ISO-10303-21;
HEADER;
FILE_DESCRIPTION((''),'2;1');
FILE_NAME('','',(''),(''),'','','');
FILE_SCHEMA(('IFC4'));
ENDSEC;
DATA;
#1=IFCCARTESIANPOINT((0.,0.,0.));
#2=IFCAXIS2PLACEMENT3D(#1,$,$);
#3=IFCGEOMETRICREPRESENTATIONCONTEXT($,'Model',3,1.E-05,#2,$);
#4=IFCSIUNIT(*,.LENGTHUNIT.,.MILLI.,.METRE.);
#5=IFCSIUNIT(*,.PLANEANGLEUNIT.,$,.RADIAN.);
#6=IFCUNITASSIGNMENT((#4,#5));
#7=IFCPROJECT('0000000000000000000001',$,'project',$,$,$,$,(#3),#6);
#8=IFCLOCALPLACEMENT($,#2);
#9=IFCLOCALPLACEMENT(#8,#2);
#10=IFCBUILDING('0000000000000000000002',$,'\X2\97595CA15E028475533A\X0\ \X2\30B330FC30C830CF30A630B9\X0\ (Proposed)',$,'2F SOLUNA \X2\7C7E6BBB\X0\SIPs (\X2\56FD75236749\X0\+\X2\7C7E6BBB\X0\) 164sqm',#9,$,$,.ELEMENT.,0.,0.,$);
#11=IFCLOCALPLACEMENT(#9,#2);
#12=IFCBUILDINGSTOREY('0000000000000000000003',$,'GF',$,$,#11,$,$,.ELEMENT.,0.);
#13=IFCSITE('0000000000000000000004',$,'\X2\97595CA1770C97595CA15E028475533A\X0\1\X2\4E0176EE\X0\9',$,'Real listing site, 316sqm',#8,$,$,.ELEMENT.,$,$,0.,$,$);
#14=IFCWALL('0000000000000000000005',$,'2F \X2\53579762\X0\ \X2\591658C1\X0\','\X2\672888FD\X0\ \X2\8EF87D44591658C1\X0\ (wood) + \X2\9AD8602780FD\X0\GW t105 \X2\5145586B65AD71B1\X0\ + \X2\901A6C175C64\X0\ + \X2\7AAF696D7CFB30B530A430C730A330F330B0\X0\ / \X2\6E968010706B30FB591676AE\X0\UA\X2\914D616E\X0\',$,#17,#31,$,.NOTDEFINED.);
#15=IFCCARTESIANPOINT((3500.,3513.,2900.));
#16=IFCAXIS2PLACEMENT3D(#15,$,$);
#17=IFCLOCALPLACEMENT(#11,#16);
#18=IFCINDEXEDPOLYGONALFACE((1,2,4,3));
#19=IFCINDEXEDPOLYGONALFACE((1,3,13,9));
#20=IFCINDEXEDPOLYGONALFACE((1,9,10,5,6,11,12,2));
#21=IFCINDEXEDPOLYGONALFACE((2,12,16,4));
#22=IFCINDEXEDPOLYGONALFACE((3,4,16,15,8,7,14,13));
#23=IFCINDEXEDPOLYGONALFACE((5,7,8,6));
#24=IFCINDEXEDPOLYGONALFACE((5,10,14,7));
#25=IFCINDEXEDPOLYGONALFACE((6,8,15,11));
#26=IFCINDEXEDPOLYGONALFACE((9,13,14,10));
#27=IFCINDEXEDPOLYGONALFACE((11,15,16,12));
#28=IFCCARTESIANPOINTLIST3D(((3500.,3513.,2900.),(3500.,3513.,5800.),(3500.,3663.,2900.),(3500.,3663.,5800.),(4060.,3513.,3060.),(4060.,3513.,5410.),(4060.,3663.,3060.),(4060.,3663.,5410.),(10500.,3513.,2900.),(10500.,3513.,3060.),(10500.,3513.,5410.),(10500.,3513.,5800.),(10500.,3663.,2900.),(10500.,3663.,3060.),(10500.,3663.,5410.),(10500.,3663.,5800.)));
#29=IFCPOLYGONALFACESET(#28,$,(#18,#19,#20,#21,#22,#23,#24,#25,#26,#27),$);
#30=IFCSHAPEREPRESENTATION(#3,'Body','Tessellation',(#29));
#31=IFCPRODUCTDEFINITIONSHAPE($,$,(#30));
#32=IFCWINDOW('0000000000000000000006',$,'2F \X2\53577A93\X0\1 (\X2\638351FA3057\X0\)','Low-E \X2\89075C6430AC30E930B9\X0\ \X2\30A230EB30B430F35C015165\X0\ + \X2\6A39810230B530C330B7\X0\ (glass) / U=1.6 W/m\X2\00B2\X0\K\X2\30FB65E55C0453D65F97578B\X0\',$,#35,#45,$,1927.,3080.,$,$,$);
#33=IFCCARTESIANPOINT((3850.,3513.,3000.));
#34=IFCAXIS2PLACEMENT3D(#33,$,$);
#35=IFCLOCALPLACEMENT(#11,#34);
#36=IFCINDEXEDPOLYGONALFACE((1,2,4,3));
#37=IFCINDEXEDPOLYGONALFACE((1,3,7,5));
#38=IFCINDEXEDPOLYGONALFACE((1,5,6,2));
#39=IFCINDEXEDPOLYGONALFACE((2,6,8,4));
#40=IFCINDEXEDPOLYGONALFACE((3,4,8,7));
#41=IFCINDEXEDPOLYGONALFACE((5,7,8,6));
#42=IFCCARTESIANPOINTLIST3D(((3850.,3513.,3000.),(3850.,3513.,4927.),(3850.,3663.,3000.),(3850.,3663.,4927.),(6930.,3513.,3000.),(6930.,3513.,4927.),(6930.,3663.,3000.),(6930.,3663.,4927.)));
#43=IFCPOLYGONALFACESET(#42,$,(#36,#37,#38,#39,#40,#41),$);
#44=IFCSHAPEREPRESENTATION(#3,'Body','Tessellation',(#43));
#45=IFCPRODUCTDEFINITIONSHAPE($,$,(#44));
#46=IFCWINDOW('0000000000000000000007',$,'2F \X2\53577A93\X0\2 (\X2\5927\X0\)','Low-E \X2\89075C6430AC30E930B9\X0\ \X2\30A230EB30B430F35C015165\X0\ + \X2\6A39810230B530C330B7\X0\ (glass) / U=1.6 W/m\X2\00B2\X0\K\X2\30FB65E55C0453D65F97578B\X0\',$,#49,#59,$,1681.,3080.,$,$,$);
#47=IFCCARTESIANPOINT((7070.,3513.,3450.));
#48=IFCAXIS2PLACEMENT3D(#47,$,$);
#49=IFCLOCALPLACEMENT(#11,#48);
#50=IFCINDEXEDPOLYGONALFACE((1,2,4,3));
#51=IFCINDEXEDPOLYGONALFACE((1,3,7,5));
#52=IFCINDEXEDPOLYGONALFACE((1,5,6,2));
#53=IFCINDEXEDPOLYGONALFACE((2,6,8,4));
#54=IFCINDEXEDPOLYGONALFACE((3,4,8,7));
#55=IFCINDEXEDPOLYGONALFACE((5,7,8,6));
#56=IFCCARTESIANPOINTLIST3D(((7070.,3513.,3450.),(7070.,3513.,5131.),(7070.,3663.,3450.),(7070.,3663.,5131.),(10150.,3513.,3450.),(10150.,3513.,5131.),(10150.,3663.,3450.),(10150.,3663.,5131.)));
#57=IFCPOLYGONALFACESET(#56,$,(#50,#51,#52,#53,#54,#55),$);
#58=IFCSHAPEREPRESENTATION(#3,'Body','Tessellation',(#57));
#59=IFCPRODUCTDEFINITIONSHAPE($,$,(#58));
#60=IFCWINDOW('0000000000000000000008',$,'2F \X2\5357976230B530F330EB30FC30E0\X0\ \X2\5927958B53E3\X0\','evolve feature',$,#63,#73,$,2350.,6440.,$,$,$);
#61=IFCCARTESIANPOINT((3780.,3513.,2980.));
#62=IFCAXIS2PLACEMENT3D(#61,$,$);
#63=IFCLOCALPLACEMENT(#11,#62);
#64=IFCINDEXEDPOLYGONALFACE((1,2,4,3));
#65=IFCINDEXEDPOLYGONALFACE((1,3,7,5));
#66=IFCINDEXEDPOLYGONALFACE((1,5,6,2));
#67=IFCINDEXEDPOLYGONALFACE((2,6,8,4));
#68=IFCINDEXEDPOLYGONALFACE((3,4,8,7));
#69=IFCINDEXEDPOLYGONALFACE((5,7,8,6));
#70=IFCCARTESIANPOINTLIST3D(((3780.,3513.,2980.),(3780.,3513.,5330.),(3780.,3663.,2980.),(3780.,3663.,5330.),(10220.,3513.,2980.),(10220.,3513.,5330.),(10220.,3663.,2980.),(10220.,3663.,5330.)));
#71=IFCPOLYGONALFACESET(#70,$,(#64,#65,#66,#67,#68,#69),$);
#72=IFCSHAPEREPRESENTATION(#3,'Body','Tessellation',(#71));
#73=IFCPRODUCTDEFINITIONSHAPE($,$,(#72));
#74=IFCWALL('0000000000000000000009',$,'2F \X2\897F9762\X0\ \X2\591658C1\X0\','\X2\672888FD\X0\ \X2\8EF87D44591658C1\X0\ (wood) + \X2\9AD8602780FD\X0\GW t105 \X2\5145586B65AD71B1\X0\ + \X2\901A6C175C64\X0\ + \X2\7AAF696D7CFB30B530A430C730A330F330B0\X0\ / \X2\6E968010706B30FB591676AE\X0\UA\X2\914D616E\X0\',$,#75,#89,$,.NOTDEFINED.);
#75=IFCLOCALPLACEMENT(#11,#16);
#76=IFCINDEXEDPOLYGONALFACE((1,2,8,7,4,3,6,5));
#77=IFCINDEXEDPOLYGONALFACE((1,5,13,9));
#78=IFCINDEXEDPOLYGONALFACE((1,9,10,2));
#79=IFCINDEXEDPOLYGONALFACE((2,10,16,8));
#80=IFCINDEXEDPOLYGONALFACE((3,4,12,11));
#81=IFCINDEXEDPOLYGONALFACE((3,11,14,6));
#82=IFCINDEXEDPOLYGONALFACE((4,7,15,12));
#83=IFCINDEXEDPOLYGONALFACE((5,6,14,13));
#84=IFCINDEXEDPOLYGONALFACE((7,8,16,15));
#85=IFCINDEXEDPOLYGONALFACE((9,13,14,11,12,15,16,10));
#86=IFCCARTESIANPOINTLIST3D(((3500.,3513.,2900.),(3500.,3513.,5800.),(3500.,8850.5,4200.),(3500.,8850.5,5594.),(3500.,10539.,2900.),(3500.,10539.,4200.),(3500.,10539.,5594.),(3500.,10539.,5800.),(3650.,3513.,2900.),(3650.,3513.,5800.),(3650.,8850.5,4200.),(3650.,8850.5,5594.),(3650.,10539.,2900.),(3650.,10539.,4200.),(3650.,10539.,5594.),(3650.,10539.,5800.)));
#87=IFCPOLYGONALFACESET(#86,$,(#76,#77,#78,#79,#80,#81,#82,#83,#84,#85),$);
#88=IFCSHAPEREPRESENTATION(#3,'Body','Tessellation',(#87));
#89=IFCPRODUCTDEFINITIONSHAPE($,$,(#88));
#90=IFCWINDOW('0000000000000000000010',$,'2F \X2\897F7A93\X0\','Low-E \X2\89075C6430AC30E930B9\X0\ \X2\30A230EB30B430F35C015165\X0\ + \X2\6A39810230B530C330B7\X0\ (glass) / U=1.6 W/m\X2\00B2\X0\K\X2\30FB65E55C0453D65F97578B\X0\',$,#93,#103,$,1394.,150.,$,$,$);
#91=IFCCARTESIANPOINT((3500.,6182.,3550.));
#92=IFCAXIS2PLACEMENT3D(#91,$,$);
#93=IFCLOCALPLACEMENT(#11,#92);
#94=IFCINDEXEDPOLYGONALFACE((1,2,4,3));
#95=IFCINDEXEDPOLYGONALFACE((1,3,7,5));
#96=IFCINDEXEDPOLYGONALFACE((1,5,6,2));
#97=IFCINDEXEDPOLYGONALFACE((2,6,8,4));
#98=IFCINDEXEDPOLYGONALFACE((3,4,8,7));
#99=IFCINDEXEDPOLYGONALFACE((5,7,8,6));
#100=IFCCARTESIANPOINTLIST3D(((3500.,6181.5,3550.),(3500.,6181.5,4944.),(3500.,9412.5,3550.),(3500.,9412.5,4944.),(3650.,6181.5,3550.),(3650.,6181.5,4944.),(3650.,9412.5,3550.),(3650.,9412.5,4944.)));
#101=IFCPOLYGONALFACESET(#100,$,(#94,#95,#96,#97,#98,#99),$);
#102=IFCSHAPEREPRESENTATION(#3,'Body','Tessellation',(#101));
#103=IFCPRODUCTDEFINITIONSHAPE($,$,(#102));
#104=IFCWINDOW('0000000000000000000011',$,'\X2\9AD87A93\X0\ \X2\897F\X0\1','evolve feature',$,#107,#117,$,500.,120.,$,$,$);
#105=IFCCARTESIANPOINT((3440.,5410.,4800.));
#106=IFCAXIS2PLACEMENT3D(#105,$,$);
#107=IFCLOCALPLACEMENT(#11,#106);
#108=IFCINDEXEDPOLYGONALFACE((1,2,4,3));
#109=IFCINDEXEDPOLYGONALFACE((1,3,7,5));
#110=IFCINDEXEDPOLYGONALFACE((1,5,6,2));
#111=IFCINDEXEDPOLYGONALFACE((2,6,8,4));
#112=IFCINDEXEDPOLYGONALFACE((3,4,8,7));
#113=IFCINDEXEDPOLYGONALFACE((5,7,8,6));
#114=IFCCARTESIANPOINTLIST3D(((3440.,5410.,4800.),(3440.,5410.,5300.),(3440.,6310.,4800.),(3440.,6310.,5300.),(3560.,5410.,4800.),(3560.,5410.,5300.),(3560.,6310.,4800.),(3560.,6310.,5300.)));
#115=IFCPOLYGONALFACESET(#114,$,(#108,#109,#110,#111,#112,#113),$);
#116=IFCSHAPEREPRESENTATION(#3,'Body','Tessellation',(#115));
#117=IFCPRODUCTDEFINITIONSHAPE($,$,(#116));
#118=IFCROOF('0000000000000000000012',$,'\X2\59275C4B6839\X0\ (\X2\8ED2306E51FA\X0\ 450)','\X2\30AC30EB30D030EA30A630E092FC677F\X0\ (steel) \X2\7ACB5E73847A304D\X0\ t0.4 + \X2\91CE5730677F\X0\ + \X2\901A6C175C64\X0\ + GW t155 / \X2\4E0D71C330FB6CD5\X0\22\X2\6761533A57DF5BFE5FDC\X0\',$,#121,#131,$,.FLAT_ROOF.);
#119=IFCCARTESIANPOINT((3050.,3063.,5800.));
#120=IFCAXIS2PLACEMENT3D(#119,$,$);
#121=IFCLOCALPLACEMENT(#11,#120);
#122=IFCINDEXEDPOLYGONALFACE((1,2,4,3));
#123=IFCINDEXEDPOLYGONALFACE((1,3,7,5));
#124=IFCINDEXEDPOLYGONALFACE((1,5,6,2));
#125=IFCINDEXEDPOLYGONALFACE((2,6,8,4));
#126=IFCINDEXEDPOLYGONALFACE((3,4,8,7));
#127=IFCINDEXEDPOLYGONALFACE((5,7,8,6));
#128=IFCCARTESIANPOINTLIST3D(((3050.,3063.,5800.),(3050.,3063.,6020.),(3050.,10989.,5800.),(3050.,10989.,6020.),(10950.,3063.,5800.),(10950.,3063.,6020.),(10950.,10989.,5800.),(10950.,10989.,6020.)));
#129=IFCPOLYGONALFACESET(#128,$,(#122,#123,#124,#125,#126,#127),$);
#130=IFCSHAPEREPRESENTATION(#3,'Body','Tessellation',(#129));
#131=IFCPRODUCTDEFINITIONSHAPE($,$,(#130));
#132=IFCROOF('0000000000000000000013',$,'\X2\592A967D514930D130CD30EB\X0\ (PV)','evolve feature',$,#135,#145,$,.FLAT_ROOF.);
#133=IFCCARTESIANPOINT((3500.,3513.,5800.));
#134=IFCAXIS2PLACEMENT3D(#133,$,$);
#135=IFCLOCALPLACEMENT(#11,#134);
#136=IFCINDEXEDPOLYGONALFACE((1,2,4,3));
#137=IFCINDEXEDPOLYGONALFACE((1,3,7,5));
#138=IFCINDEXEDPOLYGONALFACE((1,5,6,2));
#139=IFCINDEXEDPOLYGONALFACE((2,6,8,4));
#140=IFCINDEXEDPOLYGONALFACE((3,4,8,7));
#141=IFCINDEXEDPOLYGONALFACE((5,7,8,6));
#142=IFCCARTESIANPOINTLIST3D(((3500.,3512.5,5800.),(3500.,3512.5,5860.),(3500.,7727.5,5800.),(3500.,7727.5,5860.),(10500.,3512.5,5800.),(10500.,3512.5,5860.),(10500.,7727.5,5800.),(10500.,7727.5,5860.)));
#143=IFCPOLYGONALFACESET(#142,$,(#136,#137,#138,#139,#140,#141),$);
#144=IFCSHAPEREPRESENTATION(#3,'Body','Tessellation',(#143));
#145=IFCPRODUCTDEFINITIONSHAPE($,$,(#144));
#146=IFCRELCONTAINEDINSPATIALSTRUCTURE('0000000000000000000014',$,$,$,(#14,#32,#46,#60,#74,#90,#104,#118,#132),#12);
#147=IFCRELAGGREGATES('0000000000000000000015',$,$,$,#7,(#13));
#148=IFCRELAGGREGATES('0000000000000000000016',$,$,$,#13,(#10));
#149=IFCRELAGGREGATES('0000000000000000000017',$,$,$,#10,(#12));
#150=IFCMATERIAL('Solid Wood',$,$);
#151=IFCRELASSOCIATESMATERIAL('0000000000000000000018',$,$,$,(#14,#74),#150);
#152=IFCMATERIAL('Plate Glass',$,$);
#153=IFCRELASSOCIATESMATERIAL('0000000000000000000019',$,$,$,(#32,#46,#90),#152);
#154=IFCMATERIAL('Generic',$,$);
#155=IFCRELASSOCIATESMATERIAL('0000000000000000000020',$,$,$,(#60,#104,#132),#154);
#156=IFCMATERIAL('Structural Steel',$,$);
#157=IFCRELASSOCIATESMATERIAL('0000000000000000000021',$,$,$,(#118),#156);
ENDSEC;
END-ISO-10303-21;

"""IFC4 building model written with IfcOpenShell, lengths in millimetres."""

from ifc_helpers import new_model, si_unit, frame, frame_2d, origin, place, context, project, spatial, rectangle, extrude, material, element, fill, save


model = new_model("IFC4")

# Units and contexts
model_context = context("Model", 3, precision=1e-05, world=origin())
ifc_project = project(units=[si_unit("LENGTHUNIT", "METRE", prefix="MILLI"), si_unit("PLANEANGLEUNIT", "RADIAN")], contexts=[model_context])

# Site, building, storey
site_placement = place(None, origin())
site = spatial("IfcSite", under=ifc_project, at=site_placement, Name="静岡県静岡市葵区1丁目9", ObjectType="Real listing site, 316sqm", CompositionType="ELEMENT", RefElevation=0.0)
building_placement = place(site_placement, origin())
building = spatial("IfcBuilding", under=site, at=building_placement, Name="静岡市葵区 コートハウス (Proposed)", ObjectType="2F SOLUNA 籾殻SIPs (国産杉+籾殻) 164sqm", CompositionType="ELEMENT", ElevationOfRefHeight=0.0, ElevationOfTerrain=0.0)
storey_placement = place(building_placement, origin())
storey = spatial("IfcBuildingStorey", under=building, at=storey_placement, Name="GF", CompositionType="ELEMENT", Elevation=0.0)

# Shared definitions
ifc_material_1 = material(Name="Solid Wood")
ifc_material_2 = material(Name="Generic")

# Shared definitions
ifc_material_3 = material(Name="Plate Glass")

# Walls, openings, windows
wall_1_placement = place(storey_placement, frame((3500.0, 3513.0, 2900.0)))
wall_1 = element("IfcWall", 1, at=wall_1_placement, inside=storey, material=ifc_material_1, Name="2F 南面 外壁", Description="木製 軸組外壁 (wood) + 高性能GW t105 充填断熱 + 通気層 + 窯業系サイディング / 準耐火・外皮UA配慮", PredefinedType="NOTDEFINED", context=model_context, shape_type="SweptSolid", body=[
    extrude(rectangle(XDim=7000.0, YDim=150.0, at=frame_2d((3500.0, 75.0))), frame((3500.0, 3513.0, 2900.0)), (0.0, 0.0, 1.0), 2900.0),
])
opening_1_placement = place(storey_placement, frame((3850.0, 3513.0, 3000.0)))
opening_1 = element("IfcOpeningElement", 2, at=opening_1_placement, cuts=wall_1, PredefinedType="NOTDEFINED", context=model_context, shape_type="SweptSolid", body=[
    extrude(rectangle(XDim=3080.0, YDim=150.0, at=frame_2d((1540.0, 75.0))), frame((3850.0, 3513.0, 3000.0)), (0.0, 0.0, 1.0), 1927.0),
])
opening_2_placement = place(storey_placement, frame((7070.0, 3513.0, 3450.0)))
opening_2 = element("IfcOpeningElement", 3, at=opening_2_placement, cuts=wall_1, PredefinedType="NOTDEFINED", context=model_context, shape_type="SweptSolid", body=[
    extrude(rectangle(XDim=3080.0, YDim=150.0, at=frame_2d((1540.0, 75.0))), frame((7070.0, 3513.0, 3450.0)), (0.0, 0.0, 1.0), 1681.0),
])
opening_3_placement = place(storey_placement, frame((3780.0, 3513.0, 2980.0)))
opening_3 = element("IfcOpeningElement", 4, at=opening_3_placement, cuts=wall_1, PredefinedType="NOTDEFINED", context=model_context, shape_type="SweptSolid", body=[
    extrude(rectangle(XDim=6440.0, YDim=150.0, at=frame_2d((3220.0, 75.0))), frame((3780.0, 3513.0, 2980.0)), (0.0, 0.0, 1.0), 2350.0),
])
window_1_placement = place(storey_placement, frame((3850.0, 3513.0, 3000.0)))
window_1 = element("IfcWindow", 5, at=window_1_placement, inside=storey, material=ifc_material_3, Name="2F 南窓1 (掃出し)", Description="Low-E 複層ガラス アルゴン封入 + 樹脂サッシ (glass) / U=1.6 W/m²K・日射取得型", OverallHeight=1927.0, OverallWidth=3080.0, context=model_context, shape_type="SweptSolid", body=[
    extrude(rectangle(XDim=3080.0, YDim=150.0, at=frame_2d((1540.0, 75.0))), frame((3850.0, 3513.0, 3000.0)), (0.0, 0.0, 1.0), 1927.0),
])
fill(opening_1, window_1)
window_2_placement = place(storey_placement, frame((7070.0, 3513.0, 3450.0)))
window_2 = element("IfcWindow", 6, at=window_2_placement, inside=storey, material=ifc_material_3, Name="2F 南窓2 (大)", Description="Low-E 複層ガラス アルゴン封入 + 樹脂サッシ (glass) / U=1.6 W/m²K・日射取得型", OverallHeight=1681.0, OverallWidth=3080.0, context=model_context, shape_type="SweptSolid", body=[
    extrude(rectangle(XDim=3080.0, YDim=150.0, at=frame_2d((1540.0, 75.0))), frame((7070.0, 3513.0, 3450.0)), (0.0, 0.0, 1.0), 1681.0),
])
fill(opening_2, window_2)
window_3_placement = place(storey_placement, frame((3780.0, 3513.0, 2980.0)))
window_3 = element("IfcWindow", 7, at=window_3_placement, inside=storey, material=ifc_material_2, Name="2F 南面サンルーム 大開口", Description="evolve feature", OverallHeight=2350.0, OverallWidth=6440.0, context=model_context, shape_type="SweptSolid", body=[
    extrude(rectangle(XDim=6440.0, YDim=150.0, at=frame_2d((3220.0, 75.0))), frame((3780.0, 3513.0, 2980.0)), (0.0, 0.0, 1.0), 2350.0),
])
fill(opening_3, window_3)
wall_2_placement = place(storey_placement, frame((3500.0, 3513.0, 2900.0)))
wall_2 = element("IfcWall", 8, at=wall_2_placement, inside=storey, material=ifc_material_1, Name="2F 西面 外壁", Description="木製 軸組外壁 (wood) + 高性能GW t105 充填断熱 + 通気層 + 窯業系サイディング / 準耐火・外皮UA配慮", PredefinedType="NOTDEFINED", context=model_context, shape_type="SweptSolid", body=[
    extrude(rectangle(XDim=150.0, YDim=7026.0, at=frame_2d((75.0, 3513.0))), frame((3500.0, 3513.0, 2900.0)), (0.0, 0.0, 1.0), 2900.0),
])
opening_4_placement = place(storey_placement, frame((3500.0, 6182.0, 3550.0)))
opening_4 = element("IfcOpeningElement", 9, at=opening_4_placement, cuts=wall_2, PredefinedType="NOTDEFINED", context=model_context, shape_type="SweptSolid", body=[
    extrude(rectangle(XDim=150.0, YDim=3231.0, at=frame_2d((75.0, 1615.0))), frame((3500.0, 6182.0, 3550.0)), (0.0, 0.0, 1.0), 1394.0),
])
opening_5_placement = place(storey_placement, frame((3440.0, 5410.0, 4800.0)))
opening_5 = element("IfcOpeningElement", 10, at=opening_5_placement, cuts=wall_2, PredefinedType="NOTDEFINED", context=model_context, shape_type="SweptSolid", body=[
    extrude(rectangle(XDim=120.0, YDim=900.0, at=frame_2d((60.0, 450.0))), frame((3440.0, 5410.0, 4800.0)), (0.0, 0.0, 1.0), 500.0),
])
window_4_placement = place(storey_placement, frame((3500.0, 6182.0, 3550.0)))
window_4 = element("IfcWindow", 11, at=window_4_placement, inside=storey, material=ifc_material_3, Name="2F 西窓", Description="Low-E 複層ガラス アルゴン封入 + 樹脂サッシ (glass) / U=1.6 W/m²K・日射取得型", OverallHeight=1394.0, OverallWidth=150.0, context=model_context, shape_type="SweptSolid", body=[
    extrude(rectangle(XDim=150.0, YDim=3231.0, at=frame_2d((75.0, 1615.0))), frame((3500.0, 6182.0, 3550.0)), (0.0, 0.0, 1.0), 1394.0),
])
fill(opening_4, window_4)
window_5_placement = place(storey_placement, frame((3440.0, 5410.0, 4800.0)))
window_5 = element("IfcWindow", 12, at=window_5_placement, inside=storey, material=ifc_material_2, Name="高窓 西1", Description="evolve feature", OverallHeight=500.0, OverallWidth=120.0, context=model_context, shape_type="SweptSolid", body=[
    extrude(rectangle(XDim=120.0, YDim=900.0, at=frame_2d((60.0, 450.0))), frame((3440.0, 5410.0, 4800.0)), (0.0, 0.0, 1.0), 500.0),
])
fill(opening_5, window_5)

# Roofs
ifc_material_4 = material(Name="Structural Steel")
roof_1_placement = place(storey_placement, frame((3050.0, 3063.0, 5800.0)))
element("IfcRoof", 13, at=roof_1_placement, inside=storey, material=ifc_material_4, Name="大屋根 (軒の出 450)", Description="ガルバリウム鋼板 (steel) 立平葺き t0.4 + 野地板 + 通気層 + GW t155 / 不燃・法22条区域対応", PredefinedType="FLAT_ROOF", context=model_context, shape_type="SweptSolid", body=[
    extrude(rectangle(XDim=7900.0, YDim=7926.0, at=frame_2d((3950.0, 3963.0))), frame((3050.0, 3063.0, 5800.0)), (0.0, 0.0, 1.0), 220.0),
])
roof_2_placement = place(storey_placement, frame((3500.0, 3513.0, 5800.0)))
element("IfcRoof", 14, at=roof_2_placement, inside=storey, material=ifc_material_2, Name="太陽光パネル (PV)", Description="evolve feature", PredefinedType="FLAT_ROOF", context=model_context, shape_type="SweptSolid", body=[
    extrude(rectangle(XDim=7000.0, YDim=4215.0, at=frame_2d((3500.0, 2107.0))), frame((3500.0, 3513.0, 5800.0)), (0.0, 0.0, 1.0), 60.0),
])

save(model, "model.ifc")
